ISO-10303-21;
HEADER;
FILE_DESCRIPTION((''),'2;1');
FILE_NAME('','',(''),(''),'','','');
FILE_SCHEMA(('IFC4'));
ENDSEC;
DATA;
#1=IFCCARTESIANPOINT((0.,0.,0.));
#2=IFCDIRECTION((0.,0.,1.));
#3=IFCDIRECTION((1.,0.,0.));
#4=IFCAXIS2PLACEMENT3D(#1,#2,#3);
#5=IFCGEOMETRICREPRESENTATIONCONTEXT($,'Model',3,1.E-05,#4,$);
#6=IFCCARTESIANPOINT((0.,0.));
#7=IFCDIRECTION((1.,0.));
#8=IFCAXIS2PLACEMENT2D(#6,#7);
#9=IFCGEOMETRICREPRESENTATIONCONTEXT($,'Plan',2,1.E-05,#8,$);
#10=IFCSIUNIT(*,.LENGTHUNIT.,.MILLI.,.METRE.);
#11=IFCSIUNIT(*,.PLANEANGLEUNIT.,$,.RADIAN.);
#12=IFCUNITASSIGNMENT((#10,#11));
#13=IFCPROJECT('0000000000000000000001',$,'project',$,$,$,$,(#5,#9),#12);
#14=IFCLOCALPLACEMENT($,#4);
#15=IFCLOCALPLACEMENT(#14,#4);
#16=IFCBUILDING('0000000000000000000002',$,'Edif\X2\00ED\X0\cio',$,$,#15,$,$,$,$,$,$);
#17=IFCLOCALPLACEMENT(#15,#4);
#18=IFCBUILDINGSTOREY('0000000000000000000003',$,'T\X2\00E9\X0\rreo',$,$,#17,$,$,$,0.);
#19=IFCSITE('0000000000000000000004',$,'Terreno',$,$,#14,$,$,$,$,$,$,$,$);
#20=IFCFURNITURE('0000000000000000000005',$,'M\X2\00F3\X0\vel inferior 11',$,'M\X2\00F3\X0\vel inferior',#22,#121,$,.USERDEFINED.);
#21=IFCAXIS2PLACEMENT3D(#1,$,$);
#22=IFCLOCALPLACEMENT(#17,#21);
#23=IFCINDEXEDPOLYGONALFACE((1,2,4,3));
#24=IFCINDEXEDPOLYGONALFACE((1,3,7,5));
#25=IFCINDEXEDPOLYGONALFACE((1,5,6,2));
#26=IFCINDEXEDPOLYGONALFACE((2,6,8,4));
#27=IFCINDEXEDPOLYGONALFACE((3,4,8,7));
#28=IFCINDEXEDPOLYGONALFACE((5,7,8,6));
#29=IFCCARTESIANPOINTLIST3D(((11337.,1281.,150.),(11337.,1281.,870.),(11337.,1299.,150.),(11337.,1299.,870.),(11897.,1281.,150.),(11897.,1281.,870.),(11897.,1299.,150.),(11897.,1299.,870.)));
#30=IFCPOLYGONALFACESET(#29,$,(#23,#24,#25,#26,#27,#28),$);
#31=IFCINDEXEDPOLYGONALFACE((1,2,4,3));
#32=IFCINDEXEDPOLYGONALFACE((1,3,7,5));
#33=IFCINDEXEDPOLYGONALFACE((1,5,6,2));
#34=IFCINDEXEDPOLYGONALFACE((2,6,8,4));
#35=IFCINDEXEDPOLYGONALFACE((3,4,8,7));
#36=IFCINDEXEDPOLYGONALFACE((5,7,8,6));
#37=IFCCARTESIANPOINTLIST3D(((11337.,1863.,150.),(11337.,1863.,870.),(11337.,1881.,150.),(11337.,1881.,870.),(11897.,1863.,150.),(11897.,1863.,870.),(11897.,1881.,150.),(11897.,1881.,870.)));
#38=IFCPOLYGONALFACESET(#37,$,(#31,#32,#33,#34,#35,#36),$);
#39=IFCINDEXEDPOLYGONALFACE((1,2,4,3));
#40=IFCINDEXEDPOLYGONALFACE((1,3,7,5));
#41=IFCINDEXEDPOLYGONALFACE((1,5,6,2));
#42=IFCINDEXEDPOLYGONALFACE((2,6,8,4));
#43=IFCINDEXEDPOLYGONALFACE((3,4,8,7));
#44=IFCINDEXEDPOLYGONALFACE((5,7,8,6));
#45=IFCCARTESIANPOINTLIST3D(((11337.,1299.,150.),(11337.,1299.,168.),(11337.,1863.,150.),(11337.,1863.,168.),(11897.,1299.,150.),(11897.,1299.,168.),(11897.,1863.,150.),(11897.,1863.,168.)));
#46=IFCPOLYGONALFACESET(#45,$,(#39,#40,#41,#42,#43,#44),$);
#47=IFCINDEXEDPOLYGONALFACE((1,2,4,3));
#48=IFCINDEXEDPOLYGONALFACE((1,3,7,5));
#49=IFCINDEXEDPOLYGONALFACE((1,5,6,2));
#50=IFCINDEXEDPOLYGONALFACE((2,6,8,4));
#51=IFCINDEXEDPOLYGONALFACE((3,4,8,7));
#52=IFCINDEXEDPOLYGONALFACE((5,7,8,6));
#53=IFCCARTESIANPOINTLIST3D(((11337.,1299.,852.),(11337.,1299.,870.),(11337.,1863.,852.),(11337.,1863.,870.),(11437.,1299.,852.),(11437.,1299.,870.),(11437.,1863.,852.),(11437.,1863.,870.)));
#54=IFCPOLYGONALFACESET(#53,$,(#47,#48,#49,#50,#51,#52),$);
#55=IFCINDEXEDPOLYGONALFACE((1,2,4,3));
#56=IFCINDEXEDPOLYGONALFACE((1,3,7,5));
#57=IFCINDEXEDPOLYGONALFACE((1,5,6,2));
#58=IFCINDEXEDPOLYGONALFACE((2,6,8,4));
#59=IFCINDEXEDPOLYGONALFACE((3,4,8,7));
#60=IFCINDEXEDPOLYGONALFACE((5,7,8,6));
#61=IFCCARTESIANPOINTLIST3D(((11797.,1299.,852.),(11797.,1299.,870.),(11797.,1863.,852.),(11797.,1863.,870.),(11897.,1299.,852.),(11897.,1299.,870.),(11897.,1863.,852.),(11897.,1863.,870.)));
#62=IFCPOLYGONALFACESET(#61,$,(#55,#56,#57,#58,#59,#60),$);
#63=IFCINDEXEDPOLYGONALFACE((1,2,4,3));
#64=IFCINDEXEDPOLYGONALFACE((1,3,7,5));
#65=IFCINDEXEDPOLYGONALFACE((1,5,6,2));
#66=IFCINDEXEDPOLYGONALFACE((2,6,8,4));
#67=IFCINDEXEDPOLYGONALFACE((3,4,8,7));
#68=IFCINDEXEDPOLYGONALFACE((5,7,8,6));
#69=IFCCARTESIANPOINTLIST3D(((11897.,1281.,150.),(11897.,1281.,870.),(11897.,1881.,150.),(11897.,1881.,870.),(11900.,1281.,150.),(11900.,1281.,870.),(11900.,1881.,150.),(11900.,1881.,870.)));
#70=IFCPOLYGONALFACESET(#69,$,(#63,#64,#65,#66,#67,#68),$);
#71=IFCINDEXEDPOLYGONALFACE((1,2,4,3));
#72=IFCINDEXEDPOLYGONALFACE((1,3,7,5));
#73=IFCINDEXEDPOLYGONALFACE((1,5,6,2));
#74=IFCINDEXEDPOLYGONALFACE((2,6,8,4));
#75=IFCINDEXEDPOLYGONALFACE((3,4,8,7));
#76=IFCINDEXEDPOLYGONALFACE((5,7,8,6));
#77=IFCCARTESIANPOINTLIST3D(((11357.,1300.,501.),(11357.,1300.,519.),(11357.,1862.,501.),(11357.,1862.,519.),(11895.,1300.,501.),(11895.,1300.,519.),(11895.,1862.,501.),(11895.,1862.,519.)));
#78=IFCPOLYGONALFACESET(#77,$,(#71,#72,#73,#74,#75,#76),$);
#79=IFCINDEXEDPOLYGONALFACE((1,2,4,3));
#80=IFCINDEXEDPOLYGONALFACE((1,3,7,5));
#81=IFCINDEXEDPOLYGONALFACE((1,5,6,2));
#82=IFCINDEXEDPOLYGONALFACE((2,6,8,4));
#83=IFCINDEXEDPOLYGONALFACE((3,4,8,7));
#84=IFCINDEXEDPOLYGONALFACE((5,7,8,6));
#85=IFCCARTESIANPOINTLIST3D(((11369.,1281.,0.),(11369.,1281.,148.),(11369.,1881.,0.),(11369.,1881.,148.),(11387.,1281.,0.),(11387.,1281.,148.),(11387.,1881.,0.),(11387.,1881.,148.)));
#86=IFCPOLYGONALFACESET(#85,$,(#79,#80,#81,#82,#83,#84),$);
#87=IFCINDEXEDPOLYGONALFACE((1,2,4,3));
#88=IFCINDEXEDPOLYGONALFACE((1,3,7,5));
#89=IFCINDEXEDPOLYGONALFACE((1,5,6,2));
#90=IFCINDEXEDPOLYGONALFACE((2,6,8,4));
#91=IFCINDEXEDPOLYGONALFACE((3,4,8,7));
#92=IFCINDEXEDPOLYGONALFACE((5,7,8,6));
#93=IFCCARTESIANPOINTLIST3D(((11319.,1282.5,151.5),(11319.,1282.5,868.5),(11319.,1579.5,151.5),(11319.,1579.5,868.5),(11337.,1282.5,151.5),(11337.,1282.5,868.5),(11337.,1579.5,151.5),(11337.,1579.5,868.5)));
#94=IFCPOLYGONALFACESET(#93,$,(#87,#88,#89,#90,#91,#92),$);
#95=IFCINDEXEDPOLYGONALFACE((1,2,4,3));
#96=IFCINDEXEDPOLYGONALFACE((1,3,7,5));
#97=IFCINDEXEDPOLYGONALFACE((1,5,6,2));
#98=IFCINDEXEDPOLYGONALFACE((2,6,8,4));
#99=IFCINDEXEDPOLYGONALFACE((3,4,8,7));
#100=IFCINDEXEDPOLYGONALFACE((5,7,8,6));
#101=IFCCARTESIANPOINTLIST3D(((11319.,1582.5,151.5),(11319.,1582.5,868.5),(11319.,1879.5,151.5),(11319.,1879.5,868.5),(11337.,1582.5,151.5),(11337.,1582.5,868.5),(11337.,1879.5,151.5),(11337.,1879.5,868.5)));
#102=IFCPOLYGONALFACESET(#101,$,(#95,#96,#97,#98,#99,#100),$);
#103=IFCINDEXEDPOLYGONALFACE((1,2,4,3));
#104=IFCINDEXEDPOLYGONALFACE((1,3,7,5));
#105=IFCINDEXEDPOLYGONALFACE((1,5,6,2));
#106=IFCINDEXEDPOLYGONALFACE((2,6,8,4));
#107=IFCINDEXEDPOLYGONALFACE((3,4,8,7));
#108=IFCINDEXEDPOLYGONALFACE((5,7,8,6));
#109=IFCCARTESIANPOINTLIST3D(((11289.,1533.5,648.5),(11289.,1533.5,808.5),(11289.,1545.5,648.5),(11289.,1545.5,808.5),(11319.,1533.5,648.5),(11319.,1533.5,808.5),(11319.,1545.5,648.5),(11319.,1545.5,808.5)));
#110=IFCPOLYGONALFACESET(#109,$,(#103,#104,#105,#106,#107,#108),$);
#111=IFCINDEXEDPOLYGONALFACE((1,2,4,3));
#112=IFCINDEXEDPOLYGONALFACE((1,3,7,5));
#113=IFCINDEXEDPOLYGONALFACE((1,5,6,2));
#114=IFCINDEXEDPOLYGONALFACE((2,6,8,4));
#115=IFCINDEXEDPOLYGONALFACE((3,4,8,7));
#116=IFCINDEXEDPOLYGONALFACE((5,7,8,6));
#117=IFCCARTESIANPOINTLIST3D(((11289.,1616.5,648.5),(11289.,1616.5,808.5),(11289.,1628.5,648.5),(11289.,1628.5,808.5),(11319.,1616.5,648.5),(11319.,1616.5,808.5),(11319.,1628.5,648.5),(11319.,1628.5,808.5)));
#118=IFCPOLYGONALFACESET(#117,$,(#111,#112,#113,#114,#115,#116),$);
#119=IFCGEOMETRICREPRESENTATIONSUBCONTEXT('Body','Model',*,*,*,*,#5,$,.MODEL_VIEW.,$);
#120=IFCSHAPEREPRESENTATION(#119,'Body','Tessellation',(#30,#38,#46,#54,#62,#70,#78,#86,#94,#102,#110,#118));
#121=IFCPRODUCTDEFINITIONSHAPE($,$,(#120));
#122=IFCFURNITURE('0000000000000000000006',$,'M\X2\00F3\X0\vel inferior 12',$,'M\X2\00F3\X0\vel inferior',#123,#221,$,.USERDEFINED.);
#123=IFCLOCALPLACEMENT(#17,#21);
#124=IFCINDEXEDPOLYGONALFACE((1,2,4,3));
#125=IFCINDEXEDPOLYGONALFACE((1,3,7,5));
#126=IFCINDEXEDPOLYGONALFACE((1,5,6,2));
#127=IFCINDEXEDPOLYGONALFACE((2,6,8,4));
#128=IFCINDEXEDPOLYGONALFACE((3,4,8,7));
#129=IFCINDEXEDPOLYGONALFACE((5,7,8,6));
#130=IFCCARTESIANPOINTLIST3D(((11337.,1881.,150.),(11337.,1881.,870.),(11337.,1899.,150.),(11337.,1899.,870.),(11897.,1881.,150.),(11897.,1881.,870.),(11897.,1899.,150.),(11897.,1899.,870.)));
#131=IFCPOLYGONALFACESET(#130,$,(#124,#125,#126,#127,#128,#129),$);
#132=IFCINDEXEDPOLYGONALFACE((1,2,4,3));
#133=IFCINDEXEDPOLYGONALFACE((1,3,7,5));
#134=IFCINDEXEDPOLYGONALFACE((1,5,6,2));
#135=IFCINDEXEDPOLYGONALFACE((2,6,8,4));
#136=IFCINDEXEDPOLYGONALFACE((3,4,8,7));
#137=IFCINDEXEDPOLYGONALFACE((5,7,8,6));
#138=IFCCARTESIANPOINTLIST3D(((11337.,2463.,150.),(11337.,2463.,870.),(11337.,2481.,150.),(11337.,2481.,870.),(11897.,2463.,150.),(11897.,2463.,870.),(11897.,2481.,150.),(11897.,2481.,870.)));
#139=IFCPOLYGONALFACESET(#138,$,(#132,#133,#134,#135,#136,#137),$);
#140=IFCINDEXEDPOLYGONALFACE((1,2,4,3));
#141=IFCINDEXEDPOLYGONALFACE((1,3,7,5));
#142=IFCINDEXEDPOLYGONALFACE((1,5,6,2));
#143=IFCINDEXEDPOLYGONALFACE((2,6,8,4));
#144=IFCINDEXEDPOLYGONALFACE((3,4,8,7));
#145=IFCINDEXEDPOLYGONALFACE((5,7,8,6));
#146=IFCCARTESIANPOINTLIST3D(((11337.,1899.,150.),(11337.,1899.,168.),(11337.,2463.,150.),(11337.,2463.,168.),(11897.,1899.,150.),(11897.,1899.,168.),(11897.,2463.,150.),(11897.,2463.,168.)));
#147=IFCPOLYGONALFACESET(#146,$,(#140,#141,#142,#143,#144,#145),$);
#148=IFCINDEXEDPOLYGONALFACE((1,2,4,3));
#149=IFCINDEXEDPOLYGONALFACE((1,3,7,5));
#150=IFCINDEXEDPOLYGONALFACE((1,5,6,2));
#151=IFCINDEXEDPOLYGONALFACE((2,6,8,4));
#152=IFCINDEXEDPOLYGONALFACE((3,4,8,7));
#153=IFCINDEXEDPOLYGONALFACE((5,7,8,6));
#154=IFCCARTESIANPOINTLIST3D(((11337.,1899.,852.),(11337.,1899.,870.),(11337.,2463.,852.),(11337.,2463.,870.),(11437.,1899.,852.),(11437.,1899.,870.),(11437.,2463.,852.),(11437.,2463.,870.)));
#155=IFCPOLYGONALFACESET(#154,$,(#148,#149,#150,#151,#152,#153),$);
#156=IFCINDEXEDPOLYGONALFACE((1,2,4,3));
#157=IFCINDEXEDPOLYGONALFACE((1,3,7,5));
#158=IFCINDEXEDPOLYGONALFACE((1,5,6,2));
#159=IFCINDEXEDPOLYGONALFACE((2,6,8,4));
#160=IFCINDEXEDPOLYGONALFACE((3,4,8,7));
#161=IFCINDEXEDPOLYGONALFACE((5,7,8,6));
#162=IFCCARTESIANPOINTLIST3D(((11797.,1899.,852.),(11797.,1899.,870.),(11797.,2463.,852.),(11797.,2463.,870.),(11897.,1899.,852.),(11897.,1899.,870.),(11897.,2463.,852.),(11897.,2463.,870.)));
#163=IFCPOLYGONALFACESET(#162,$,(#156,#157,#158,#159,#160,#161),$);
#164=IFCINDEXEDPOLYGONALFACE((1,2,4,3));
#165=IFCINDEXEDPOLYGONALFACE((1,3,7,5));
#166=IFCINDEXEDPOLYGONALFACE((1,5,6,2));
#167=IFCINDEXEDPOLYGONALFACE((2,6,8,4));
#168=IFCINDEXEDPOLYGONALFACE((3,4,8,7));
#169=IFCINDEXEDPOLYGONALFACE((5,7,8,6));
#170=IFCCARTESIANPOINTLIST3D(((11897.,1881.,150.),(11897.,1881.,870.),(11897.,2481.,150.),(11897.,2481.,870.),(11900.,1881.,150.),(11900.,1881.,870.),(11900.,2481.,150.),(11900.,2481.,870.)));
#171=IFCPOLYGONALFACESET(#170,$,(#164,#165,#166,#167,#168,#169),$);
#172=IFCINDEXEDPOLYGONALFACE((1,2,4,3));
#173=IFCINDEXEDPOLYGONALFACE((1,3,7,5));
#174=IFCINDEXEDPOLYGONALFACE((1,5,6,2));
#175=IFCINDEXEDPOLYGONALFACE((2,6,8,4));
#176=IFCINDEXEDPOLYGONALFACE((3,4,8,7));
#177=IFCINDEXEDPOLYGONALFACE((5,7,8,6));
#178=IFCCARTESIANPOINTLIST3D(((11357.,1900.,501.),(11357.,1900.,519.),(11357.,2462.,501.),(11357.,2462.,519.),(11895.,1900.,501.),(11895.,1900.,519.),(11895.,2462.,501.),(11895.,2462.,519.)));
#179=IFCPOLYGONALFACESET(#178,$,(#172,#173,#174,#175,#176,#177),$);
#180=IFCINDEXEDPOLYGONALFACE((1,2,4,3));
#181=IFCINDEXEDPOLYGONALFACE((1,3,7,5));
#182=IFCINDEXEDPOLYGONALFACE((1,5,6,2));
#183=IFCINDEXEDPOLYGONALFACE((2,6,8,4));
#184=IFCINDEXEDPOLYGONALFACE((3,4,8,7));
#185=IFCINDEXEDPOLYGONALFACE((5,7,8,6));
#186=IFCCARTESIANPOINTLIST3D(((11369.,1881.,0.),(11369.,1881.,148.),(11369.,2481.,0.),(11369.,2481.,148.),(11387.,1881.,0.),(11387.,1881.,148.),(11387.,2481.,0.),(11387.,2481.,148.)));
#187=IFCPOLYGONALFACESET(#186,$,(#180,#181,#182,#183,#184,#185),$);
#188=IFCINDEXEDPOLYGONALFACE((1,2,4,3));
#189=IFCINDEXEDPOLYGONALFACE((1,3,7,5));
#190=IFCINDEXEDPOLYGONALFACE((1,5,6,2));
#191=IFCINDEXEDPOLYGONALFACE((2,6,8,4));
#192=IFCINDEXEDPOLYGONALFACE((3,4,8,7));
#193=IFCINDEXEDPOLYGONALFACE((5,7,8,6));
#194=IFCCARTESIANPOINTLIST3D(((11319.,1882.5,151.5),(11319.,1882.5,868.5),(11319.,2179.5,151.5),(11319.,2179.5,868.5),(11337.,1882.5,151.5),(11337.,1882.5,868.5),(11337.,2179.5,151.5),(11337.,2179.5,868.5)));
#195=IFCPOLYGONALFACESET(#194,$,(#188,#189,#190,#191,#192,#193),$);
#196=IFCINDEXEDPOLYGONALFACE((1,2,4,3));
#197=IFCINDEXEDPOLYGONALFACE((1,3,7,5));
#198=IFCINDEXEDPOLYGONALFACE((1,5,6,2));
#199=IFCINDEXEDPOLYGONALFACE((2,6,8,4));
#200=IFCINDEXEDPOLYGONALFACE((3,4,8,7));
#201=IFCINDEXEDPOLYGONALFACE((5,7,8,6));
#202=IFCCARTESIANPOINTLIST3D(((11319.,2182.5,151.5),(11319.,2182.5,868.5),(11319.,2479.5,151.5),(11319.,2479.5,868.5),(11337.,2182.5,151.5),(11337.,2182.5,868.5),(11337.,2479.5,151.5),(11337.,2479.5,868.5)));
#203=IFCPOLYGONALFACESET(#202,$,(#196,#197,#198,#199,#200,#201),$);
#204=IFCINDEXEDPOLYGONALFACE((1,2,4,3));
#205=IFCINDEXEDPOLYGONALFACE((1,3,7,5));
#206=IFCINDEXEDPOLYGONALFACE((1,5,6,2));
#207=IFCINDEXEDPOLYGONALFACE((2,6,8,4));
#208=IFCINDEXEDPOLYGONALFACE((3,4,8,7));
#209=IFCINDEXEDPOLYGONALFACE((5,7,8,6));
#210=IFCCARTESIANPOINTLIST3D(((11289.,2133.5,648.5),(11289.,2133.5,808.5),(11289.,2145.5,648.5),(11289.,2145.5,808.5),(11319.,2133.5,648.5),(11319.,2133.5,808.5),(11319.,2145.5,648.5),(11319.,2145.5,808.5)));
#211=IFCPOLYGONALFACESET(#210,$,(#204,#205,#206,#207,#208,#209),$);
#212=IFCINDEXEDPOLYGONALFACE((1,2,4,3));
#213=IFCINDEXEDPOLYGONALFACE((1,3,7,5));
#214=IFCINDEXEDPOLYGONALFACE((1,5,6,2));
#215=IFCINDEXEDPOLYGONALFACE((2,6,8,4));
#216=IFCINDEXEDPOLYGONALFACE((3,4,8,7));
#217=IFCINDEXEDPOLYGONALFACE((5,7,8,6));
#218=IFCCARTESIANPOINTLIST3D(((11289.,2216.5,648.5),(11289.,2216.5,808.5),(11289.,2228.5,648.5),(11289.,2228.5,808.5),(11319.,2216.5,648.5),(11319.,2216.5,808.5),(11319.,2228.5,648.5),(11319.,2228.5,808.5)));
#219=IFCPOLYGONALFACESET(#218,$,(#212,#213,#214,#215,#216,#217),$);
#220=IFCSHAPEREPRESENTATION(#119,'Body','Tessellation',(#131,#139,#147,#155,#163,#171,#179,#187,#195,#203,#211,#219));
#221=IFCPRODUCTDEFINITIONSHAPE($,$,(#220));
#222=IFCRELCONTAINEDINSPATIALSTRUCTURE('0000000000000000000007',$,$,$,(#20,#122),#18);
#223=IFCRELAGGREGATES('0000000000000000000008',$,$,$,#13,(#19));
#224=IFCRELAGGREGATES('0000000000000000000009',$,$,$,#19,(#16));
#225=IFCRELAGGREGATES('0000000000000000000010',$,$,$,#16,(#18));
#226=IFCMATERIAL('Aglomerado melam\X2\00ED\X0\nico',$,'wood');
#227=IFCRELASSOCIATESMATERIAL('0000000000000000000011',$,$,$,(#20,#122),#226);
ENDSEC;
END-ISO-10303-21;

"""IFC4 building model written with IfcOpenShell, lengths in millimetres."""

from ifc_helpers import new_model, si_unit, frame, frame_2d, origin, origin_with_axes, origin_2d_with_axis, place, context, subcontext, project, spatial, rectangle, extrude, material, element, save


model = new_model("IFC4")

# Units and contexts
model_context = context("Model", 3, precision=1e-05, world=origin_with_axes())
plan_context = context("Plan", 2, precision=1e-05, world=origin_2d_with_axis())
body_context = subcontext(model_context, "Body", "Model", "MODEL_VIEW")
ifc_project = project(units=[si_unit("LENGTHUNIT", "METRE", prefix="MILLI"), si_unit("PLANEANGLEUNIT", "RADIAN")], contexts=[model_context, plan_context])

# Site, building, storey
site_placement = place(None, origin_with_axes())
site = spatial("IfcSite", under=ifc_project, at=site_placement, Name="Terreno")
building_placement = place(site_placement, origin_with_axes())
building = spatial("IfcBuilding", under=site, at=building_placement, Name="Edifício")
storey_placement = place(building_placement, origin_with_axes())
storey = spatial("IfcBuildingStorey", under=building, at=storey_placement, Name="Térreo", Elevation=0.0)

# Furniture
ifc_material_1 = material(Name="Aglomerado melamínico", Category="wood")
furniture_1_placement = place(storey_placement, frame((11900.0, 1281.0, 0.0), z_axis=(0.0, 0.0, 1.0), x_axis=(0.0, 1.0, 0.0)))
element("IfcFurniture", 1, at=furniture_1_placement, inside=storey, material=ifc_material_1, Name="Móvel inferior 11", ObjectType="Móvel inferior", PredefinedType="USERDEFINED", context=body_context, shape_type="SweptSolid", body=[
    extrude(rectangle(XDim=18.0, YDim=560.0, at=frame_2d((9.0, 283.0))), frame((0.0, 0.0, 150.0)), (0.0, 0.0, 1.0), 720.0),
    extrude(rectangle(XDim=18.0, YDim=560.0, at=frame_2d((591.0, 283.0))), frame((0.0, 0.0, 150.0)), (0.0, 0.0, 1.0), 720.0),
    extrude(rectangle(XDim=564.0, YDim=560.0, at=frame_2d((300.0, 283.0))), frame((0.0, 0.0, 150.0)), (0.0, 0.0, 1.0), 18.0),
    extrude(rectangle(XDim=564.0, YDim=100.0, at=frame_2d((300.0, 513.0))), frame((0.0, 0.0, 852.0)), (0.0, 0.0, 1.0), 18.0),
    extrude(rectangle(XDim=564.0, YDim=100.0, at=frame_2d((300.0, 53.0))), frame((0.0, 0.0, 852.0)), (0.0, 0.0, 1.0), 18.0),
    extrude(rectangle(XDim=600.0, YDim=3.0, at=frame_2d((300.0, 1.5))), frame((0.0, 0.0, 150.0)), (0.0, 0.0, 1.0), 720.0),
    extrude(rectangle(XDim=562.0, YDim=538.0, at=frame_2d((300.0, 274.0))), frame((0.0, 0.0, 501.0)), (0.0, 0.0, 1.0), 18.0),
    extrude(rectangle(XDim=600.0, YDim=18.0, at=frame_2d((300.0, 522.0))), origin(), (0.0, 0.0, 1.0), 148.0),
    extrude(rectangle(XDim=297.0, YDim=18.0, at=frame_2d((150.0, 572.0))), frame((0.0, 0.0, 151.5)), (0.0, 0.0, 1.0), 717.0),
    extrude(rectangle(XDim=297.0, YDim=18.0, at=frame_2d((450.0, 572.0))), frame((0.0, 0.0, 151.5)), (0.0, 0.0, 1.0), 717.0),
    extrude(rectangle(XDim=12.0, YDim=30.0, at=frame_2d((258.5, 596.0))), frame((0.0, 0.0, 648.5)), (0.0, 0.0, 1.0), 160.0),
    extrude(rectangle(XDim=12.0, YDim=30.0, at=frame_2d((341.5, 596.0))), frame((0.0, 0.0, 648.5)), (0.0, 0.0, 1.0), 160.0),
])
furniture_2_placement = place(storey_placement, frame((11900.0, 1881.0, 0.0), z_axis=(0.0, 0.0, 1.0), x_axis=(0.0, 1.0, 0.0)))
element("IfcFurniture", 2, at=furniture_2_placement, inside=storey, material=ifc_material_1, Name="Móvel inferior 12", ObjectType="Móvel inferior", PredefinedType="USERDEFINED", context=body_context, shape_type="SweptSolid", body=[
    extrude(rectangle(XDim=18.0, YDim=560.0, at=frame_2d((9.0, 283.0))), frame((0.0, 0.0, 150.0)), (0.0, 0.0, 1.0), 720.0),
    extrude(rectangle(XDim=18.0, YDim=560.0, at=frame_2d((591.0, 283.0))), frame((0.0, 0.0, 150.0)), (0.0, 0.0, 1.0), 720.0),
    extrude(rectangle(XDim=564.0, YDim=560.0, at=frame_2d((300.0, 283.0))), frame((0.0, 0.0, 150.0)), (0.0, 0.0, 1.0), 18.0),
    extrude(rectangle(XDim=564.0, YDim=100.0, at=frame_2d((300.0, 513.0))), frame((0.0, 0.0, 852.0)), (0.0, 0.0, 1.0), 18.0),
    extrude(rectangle(XDim=564.0, YDim=100.0, at=frame_2d((300.0, 53.0))), frame((0.0, 0.0, 852.0)), (0.0, 0.0, 1.0), 18.0),
    extrude(rectangle(XDim=600.0, YDim=3.0, at=frame_2d((300.0, 1.5))), frame((0.0, 0.0, 150.0)), (0.0, 0.0, 1.0), 720.0),
    extrude(rectangle(XDim=562.0, YDim=538.0, at=frame_2d((300.0, 274.0))), frame((0.0, 0.0, 501.0)), (0.0, 0.0, 1.0), 18.0),
    extrude(rectangle(XDim=600.0, YDim=18.0, at=frame_2d((300.0, 522.0))), origin(), (0.0, 0.0, 1.0), 148.0),
    extrude(rectangle(XDim=297.0, YDim=18.0, at=frame_2d((150.0, 572.0))), frame((0.0, 0.0, 151.5)), (0.0, 0.0, 1.0), 717.0),
    extrude(rectangle(XDim=297.0, YDim=18.0, at=frame_2d((450.0, 572.0))), frame((0.0, 0.0, 151.5)), (0.0, 0.0, 1.0), 717.0),
    extrude(rectangle(XDim=12.0, YDim=30.0, at=frame_2d((258.5, 596.0))), frame((0.0, 0.0, 648.5)), (0.0, 0.0, 1.0), 160.0),
    extrude(rectangle(XDim=12.0, YDim=30.0, at=frame_2d((341.5, 596.0))), frame((0.0, 0.0, 648.5)), (0.0, 0.0, 1.0), 160.0),
])

save(model, "model.ifc")
